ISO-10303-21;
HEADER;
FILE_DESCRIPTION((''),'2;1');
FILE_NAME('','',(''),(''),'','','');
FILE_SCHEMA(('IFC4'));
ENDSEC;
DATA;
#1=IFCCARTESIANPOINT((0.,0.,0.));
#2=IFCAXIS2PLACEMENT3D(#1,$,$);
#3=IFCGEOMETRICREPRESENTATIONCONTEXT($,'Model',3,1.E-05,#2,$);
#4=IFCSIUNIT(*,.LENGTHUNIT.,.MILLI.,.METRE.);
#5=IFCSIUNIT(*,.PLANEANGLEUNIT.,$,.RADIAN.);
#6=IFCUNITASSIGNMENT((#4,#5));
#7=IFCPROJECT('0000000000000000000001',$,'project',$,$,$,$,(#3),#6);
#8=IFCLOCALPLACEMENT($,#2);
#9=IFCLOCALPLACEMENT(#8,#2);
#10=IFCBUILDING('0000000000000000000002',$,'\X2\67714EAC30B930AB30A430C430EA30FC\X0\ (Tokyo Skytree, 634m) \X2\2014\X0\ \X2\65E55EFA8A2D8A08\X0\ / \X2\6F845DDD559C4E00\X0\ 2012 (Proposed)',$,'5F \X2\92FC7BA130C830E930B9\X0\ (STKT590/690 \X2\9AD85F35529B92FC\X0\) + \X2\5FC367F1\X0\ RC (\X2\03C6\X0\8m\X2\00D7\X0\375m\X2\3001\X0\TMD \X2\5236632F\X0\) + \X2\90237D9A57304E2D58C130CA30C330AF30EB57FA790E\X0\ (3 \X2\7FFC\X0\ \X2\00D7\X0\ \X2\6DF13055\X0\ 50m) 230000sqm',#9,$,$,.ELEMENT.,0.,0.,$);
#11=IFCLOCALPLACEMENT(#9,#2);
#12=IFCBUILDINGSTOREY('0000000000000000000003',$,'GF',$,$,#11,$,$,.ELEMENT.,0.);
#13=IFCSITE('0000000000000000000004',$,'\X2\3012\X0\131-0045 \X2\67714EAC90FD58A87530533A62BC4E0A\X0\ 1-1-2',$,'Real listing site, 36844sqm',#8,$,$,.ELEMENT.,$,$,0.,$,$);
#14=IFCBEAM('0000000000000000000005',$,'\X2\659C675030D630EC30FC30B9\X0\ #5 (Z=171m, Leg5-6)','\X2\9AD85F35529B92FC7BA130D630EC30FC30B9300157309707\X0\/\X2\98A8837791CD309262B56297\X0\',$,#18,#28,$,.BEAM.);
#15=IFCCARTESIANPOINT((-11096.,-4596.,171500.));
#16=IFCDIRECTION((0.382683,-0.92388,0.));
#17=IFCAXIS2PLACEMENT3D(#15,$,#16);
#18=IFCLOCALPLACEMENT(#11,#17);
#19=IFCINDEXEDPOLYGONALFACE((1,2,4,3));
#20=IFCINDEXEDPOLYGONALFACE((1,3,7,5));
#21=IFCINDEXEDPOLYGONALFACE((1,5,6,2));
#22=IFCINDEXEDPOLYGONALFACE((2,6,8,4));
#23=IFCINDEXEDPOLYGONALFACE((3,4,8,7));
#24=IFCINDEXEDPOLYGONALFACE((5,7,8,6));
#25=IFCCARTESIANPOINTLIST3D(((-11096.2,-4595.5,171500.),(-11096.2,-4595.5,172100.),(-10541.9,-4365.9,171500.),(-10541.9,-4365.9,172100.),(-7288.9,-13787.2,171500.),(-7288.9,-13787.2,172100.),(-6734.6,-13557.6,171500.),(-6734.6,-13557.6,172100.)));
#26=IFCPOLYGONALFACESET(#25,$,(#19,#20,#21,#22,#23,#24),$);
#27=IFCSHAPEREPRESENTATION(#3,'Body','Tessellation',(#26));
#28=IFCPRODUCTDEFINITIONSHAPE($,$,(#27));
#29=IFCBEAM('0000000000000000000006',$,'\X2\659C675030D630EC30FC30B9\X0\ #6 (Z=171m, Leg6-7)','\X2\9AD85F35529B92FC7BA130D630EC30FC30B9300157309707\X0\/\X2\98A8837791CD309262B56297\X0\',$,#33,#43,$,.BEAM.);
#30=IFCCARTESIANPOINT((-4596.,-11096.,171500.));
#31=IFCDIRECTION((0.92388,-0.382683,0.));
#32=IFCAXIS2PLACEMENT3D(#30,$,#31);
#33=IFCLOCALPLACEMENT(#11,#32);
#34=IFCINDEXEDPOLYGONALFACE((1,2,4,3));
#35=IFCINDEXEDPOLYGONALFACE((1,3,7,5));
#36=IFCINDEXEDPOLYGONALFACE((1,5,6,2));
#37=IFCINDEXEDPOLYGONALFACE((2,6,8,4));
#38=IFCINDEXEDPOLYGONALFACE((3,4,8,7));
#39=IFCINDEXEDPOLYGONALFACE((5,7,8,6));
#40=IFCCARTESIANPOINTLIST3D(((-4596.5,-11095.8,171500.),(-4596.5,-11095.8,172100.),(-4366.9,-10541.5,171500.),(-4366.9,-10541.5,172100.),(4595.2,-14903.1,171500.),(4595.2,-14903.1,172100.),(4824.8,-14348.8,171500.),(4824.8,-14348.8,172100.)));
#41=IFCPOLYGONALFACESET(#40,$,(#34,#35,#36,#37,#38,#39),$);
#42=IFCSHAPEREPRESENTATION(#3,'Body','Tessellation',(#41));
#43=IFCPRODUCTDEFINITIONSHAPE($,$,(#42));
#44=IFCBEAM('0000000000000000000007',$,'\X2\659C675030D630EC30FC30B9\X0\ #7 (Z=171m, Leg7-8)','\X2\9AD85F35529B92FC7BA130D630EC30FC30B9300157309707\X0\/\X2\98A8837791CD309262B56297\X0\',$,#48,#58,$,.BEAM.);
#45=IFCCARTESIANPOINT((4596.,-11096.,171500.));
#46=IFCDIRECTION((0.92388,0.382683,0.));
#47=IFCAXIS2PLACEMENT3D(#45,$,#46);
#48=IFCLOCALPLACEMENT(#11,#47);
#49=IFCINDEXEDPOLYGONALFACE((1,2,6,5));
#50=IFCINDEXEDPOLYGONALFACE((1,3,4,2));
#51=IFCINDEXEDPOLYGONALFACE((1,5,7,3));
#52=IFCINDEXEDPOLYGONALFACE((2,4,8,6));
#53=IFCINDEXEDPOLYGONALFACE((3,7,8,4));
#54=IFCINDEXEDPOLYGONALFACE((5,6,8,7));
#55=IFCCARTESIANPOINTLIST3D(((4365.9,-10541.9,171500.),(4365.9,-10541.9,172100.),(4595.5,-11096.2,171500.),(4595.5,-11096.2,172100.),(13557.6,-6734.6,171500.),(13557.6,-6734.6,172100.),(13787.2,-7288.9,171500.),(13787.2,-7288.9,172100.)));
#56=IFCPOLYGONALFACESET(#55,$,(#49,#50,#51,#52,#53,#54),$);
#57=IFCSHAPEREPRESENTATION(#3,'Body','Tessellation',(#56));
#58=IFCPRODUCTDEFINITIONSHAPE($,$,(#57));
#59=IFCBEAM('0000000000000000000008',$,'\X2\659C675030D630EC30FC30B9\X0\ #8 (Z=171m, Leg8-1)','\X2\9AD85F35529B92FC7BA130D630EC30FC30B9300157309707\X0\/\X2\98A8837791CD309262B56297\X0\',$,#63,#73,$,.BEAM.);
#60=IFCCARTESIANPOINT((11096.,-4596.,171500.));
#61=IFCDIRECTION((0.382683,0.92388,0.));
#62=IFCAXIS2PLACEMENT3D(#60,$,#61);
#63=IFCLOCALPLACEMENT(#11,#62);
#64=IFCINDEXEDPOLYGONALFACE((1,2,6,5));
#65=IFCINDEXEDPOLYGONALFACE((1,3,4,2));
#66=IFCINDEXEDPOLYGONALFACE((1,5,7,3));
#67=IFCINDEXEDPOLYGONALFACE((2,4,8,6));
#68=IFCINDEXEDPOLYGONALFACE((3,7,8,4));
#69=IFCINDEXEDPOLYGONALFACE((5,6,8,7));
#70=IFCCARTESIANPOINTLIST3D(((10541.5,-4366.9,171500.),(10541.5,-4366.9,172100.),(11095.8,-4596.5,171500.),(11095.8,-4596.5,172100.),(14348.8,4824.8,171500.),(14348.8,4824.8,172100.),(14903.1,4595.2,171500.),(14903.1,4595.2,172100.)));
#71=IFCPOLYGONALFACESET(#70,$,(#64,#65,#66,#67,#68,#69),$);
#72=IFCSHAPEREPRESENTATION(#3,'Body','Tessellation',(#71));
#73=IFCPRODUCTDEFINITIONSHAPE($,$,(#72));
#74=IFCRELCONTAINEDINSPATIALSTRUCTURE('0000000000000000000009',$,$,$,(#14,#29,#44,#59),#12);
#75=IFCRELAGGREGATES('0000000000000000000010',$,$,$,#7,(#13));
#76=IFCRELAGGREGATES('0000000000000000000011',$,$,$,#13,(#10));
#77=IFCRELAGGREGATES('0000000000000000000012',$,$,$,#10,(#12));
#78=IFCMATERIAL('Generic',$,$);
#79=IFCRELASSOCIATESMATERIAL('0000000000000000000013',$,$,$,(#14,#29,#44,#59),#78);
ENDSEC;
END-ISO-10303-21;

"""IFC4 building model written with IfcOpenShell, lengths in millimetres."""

from ifc_helpers import new_model, si_unit, frame, frame_2d, origin, place, context, project, spatial, rectangle, extrude, material, element, save


model = new_model("IFC4")

# Units and contexts
model_context = context("Model", 3, precision=1e-05, world=origin())
ifc_project = project(units=[si_unit("LENGTHUNIT", "METRE", prefix="MILLI"), si_unit("PLANEANGLEUNIT", "RADIAN")], contexts=[model_context])

# Site, building, storey
site_placement = place(None, origin())
site = spatial("IfcSite", under=ifc_project, at=site_placement, Name="〒131-0045 東京都墨田区押上 1-1-2", ObjectType="Real listing site, 36844sqm", CompositionType="ELEMENT", RefElevation=0.0)
building_placement = place(site_placement, origin())
building = spatial("IfcBuilding", under=site, at=building_placement, Name="東京スカイツリー (Tokyo Skytree, 634m) — 日建設計 / 澄川喜一 2012 (Proposed)", ObjectType="5F 鋼管トラス (STKT590/690 高張力鋼) + 心柱 RC (φ8m×375m、TMD 制振) + 連続地中壁ナックル基礎 (3 翼 × 深さ 50m) 230000sqm", CompositionType="ELEMENT", ElevationOfRefHeight=0.0, ElevationOfTerrain=0.0)
storey_placement = place(building_placement, origin())
storey = spatial("IfcBuildingStorey", under=building, at=storey_placement, Name="GF", CompositionType="ELEMENT", Elevation=0.0)

# Shared definitions
ifc_material_1 = material(Name="Generic")

# Beams
beam_1_placement = place(storey_placement, frame((-11096.0, -4596.0, 171500.0), x_axis=(0.382683, -0.92388, 0.0)))
element("IfcBeam", 1, at=beam_1_placement, inside=storey, material=ifc_material_1, Name="斜材ブレース #5 (Z=171m, Leg5-6)", Description="高張力鋼管ブレース、地震/風荷重を抵抗", PredefinedType="BEAM", context=model_context, shape_type="SweptSolid", body=[
    extrude(rectangle(XDim=9949.0, YDim=600.0, at=frame_2d((4974.0, 300.0))), frame((-11096.0, -4596.0, 171500.0), x_axis=(0.382683, -0.92388, 0.0)), (0.0, 0.0, 1.0), 600.0),
])
beam_2_placement = place(storey_placement, frame((-4596.0, -11096.0, 171500.0), x_axis=(0.92388, -0.382683, 0.0)))
element("IfcBeam", 2, at=beam_2_placement, inside=storey, material=ifc_material_1, Name="斜材ブレース #6 (Z=171m, Leg6-7)", Description="高張力鋼管ブレース、地震/風荷重を抵抗", PredefinedType="BEAM", context=model_context, shape_type="SweptSolid", body=[
    extrude(rectangle(XDim=9949.0, YDim=600.0, at=frame_2d((4974.0, 300.0))), frame((-4596.0, -11096.0, 171500.0), x_axis=(0.92388, -0.382683, 0.0)), (0.0, 0.0, 1.0), 600.0),
])
beam_3_placement = place(storey_placement, frame((4596.0, -11096.0, 171500.0), x_axis=(0.92388, 0.382683, 0.0)))
element("IfcBeam", 3, at=beam_3_placement, inside=storey, material=ifc_material_1, Name="斜材ブレース #7 (Z=171m, Leg7-8)", Description="高張力鋼管ブレース、地震/風荷重を抵抗", PredefinedType="BEAM", context=model_context, shape_type="SweptSolid", body=[
    extrude(rectangle(XDim=9949.0, YDim=600.0, at=frame_2d((4974.0, 300.0))), frame((4596.0, -11096.0, 171500.0), x_axis=(0.92388, 0.382683, 0.0)), (0.0, 0.0, 1.0), 600.0),
])
beam_4_placement = place(storey_placement, frame((11096.0, -4596.0, 171500.0), x_axis=(0.382683, 0.92388, 0.0)))
element("IfcBeam", 4, at=beam_4_placement, inside=storey, material=ifc_material_1, Name="斜材ブレース #8 (Z=171m, Leg8-1)", Description="高張力鋼管ブレース、地震/風荷重を抵抗", PredefinedType="BEAM", context=model_context, shape_type="SweptSolid", body=[
    extrude(rectangle(XDim=9949.0, YDim=600.0, at=frame_2d((4974.0, 300.0))), frame((11096.0, -4596.0, 171500.0), x_axis=(0.382683, 0.92388, 0.0)), (0.0, 0.0, 1.0), 600.0),
])

save(model, "model.ifc")
